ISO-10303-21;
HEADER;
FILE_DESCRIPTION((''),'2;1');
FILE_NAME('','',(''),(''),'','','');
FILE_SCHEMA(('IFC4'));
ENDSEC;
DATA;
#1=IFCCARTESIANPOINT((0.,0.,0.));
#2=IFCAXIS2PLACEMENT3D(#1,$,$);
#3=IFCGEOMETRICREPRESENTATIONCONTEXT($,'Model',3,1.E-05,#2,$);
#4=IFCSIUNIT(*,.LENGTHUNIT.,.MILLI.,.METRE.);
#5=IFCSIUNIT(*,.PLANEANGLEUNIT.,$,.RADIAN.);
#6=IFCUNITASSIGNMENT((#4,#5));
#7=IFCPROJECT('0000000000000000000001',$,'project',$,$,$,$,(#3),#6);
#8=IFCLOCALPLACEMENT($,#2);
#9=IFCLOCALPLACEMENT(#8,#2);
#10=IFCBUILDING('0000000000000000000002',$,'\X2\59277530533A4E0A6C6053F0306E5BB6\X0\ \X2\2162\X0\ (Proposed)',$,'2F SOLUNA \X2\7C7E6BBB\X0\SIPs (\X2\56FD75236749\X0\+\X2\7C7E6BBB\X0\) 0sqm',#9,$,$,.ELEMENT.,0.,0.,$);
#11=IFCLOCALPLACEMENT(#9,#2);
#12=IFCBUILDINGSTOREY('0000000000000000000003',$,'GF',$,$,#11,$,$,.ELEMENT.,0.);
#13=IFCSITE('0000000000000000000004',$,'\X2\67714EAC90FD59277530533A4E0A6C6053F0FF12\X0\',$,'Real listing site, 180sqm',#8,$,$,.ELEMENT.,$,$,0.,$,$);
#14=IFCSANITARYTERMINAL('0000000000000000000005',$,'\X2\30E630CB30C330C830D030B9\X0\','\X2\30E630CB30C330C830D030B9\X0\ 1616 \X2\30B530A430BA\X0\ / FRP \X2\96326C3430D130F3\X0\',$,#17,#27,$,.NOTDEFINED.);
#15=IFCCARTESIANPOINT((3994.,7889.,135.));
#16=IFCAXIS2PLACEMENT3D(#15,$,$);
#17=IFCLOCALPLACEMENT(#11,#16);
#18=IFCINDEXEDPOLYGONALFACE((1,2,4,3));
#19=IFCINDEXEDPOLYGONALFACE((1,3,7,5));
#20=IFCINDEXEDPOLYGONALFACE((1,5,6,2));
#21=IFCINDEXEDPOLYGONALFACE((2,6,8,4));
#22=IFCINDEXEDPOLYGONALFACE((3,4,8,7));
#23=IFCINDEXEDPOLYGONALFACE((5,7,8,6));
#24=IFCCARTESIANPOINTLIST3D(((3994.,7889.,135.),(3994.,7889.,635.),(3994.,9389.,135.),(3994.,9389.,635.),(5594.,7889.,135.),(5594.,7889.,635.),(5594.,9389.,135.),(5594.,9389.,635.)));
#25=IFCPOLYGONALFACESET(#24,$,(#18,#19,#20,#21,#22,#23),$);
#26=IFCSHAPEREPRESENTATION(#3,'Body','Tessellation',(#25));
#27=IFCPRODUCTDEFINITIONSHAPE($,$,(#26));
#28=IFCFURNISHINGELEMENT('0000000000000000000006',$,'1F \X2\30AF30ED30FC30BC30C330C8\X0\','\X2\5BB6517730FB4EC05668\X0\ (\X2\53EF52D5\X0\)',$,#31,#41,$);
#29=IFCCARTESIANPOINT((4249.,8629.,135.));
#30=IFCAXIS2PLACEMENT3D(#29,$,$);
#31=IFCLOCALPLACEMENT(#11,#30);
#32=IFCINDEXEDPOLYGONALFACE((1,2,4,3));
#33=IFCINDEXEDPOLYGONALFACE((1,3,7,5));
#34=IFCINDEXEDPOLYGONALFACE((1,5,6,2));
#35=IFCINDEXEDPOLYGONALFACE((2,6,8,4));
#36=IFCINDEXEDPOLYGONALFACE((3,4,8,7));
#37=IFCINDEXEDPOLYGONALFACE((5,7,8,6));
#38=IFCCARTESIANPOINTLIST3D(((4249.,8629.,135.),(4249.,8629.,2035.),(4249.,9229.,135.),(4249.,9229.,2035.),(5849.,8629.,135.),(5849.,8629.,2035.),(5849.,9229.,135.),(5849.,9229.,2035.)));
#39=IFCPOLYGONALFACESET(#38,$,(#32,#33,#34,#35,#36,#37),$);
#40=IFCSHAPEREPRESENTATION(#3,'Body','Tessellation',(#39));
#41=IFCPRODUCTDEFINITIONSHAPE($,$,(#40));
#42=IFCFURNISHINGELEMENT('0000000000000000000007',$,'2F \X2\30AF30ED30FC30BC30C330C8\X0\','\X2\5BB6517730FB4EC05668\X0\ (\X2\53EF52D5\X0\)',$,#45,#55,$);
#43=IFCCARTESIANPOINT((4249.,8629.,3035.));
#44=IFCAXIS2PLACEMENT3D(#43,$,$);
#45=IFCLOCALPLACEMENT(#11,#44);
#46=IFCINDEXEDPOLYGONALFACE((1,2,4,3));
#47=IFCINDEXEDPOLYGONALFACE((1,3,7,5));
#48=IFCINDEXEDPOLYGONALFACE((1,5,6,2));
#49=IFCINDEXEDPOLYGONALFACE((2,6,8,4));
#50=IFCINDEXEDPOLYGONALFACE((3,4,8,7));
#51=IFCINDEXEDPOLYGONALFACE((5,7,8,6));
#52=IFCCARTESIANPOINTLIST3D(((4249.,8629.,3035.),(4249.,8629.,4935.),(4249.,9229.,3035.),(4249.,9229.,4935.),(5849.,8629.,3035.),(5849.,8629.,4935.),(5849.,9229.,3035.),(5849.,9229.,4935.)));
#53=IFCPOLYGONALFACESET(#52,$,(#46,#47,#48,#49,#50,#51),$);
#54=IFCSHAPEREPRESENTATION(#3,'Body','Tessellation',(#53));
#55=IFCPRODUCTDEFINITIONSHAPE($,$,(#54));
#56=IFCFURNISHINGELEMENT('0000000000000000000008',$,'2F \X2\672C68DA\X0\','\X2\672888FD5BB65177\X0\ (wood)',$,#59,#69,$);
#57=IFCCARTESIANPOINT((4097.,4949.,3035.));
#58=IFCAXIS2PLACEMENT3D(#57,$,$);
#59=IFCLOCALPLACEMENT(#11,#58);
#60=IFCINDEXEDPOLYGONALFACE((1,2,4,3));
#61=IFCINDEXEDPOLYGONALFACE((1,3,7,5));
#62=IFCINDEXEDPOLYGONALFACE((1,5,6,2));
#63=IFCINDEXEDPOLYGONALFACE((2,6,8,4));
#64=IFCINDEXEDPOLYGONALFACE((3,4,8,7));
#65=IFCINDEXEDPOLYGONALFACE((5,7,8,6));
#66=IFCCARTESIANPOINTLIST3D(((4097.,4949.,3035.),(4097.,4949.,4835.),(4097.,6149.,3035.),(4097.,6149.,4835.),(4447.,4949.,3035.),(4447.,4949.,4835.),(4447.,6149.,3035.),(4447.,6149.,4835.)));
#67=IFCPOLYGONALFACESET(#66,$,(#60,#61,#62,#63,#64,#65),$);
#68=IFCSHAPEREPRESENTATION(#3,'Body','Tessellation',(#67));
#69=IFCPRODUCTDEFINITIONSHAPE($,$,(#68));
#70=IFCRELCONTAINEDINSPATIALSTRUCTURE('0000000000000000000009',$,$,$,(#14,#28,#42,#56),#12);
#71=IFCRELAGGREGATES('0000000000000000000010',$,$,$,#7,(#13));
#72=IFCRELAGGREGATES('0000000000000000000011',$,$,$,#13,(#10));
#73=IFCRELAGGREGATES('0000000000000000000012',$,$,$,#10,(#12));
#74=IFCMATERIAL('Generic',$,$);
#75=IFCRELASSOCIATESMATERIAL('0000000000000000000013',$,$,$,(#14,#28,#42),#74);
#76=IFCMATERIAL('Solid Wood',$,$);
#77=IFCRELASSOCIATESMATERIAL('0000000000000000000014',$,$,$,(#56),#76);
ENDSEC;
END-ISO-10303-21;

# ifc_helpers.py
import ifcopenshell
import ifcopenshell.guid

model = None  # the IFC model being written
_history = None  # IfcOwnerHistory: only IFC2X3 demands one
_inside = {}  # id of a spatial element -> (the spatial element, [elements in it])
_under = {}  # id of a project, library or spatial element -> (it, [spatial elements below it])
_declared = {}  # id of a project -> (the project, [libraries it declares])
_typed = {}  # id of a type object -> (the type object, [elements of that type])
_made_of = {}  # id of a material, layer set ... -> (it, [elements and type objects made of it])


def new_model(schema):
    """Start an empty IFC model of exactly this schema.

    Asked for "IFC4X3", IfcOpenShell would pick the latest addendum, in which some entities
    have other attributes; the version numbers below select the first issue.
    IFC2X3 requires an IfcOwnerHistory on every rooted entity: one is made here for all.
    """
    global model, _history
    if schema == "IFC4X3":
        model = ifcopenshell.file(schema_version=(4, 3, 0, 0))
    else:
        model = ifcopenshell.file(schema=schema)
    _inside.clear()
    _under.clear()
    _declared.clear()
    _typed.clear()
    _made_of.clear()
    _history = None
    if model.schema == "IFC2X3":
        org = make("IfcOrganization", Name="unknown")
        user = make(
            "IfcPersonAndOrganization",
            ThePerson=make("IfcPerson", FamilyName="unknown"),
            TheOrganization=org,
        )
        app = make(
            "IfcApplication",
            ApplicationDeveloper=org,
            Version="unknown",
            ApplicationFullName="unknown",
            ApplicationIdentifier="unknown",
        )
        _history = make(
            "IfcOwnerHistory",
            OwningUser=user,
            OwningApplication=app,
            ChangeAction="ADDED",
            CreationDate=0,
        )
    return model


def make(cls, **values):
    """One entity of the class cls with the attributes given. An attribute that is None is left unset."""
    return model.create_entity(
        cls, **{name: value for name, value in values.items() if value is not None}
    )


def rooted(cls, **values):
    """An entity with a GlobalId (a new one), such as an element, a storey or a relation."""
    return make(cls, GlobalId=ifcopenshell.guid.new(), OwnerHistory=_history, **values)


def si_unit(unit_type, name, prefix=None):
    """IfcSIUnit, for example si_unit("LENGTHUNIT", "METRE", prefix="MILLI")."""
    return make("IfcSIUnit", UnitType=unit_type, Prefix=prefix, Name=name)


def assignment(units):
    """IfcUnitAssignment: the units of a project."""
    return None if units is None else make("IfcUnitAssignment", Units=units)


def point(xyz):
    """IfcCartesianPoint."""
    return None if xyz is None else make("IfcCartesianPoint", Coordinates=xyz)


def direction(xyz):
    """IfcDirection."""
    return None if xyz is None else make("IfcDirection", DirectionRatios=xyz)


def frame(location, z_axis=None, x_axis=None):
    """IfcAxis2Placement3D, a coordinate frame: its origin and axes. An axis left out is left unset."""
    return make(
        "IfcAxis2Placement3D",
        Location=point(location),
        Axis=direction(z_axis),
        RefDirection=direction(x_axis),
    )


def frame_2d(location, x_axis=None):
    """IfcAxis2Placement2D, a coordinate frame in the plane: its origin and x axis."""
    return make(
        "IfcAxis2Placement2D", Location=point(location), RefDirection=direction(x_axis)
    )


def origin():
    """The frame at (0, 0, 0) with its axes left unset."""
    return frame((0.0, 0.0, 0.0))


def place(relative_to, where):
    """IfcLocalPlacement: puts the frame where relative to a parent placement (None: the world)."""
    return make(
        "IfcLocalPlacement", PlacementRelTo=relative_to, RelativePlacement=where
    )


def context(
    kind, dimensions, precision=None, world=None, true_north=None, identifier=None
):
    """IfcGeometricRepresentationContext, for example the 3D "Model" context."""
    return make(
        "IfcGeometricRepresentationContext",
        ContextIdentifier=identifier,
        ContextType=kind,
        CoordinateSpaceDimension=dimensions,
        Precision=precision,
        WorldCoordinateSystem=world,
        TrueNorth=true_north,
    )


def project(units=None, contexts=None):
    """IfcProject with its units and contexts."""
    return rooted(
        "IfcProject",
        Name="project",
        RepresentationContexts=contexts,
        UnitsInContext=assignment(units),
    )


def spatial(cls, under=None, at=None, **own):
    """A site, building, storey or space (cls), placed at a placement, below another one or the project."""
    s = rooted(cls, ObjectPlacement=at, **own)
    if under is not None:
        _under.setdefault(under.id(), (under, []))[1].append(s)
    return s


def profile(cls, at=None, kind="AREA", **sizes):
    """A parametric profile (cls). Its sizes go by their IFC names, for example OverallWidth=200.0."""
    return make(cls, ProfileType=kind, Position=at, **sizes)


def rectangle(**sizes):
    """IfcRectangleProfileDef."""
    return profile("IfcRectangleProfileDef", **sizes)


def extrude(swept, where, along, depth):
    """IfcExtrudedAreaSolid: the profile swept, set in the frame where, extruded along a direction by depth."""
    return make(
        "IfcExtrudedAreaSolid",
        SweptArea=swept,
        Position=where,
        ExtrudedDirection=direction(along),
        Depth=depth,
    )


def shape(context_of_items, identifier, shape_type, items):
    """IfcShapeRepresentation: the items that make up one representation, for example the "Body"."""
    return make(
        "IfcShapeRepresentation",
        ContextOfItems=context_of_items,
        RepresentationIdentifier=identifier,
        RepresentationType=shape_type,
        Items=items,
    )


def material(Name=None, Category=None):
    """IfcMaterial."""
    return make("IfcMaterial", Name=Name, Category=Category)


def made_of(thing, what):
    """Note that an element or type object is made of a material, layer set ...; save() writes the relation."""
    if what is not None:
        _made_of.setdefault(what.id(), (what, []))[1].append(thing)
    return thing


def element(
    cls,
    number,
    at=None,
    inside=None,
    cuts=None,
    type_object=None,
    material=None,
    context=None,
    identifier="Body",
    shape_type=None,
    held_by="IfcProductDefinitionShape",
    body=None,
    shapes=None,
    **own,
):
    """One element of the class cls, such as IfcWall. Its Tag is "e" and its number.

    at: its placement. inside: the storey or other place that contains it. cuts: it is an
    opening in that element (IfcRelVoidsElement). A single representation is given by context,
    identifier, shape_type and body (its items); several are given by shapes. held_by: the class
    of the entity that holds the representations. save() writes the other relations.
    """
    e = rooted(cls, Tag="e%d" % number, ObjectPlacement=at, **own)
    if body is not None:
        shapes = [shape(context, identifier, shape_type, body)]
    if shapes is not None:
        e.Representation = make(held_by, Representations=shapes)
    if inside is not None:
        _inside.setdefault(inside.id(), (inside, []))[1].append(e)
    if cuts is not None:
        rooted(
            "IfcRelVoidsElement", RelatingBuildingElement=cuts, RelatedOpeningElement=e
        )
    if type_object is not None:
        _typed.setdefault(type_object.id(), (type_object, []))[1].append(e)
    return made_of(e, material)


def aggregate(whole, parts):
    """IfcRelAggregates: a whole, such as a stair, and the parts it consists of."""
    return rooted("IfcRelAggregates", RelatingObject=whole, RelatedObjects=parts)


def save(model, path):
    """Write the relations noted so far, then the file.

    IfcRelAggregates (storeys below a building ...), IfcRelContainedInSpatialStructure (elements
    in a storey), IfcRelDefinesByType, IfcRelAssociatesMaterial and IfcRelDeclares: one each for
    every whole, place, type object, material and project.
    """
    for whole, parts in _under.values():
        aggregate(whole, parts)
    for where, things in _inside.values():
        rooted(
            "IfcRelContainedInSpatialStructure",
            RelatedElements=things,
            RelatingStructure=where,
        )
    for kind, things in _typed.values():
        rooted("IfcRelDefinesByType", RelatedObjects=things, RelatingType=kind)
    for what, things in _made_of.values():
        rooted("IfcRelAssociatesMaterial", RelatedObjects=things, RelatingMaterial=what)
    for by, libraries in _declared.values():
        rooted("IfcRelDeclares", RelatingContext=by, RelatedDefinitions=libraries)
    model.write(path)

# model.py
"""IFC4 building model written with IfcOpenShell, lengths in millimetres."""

from ifc_helpers import new_model, si_unit, frame, frame_2d, origin, place, context, project, spatial, rectangle, extrude, material, element, save


model = new_model("IFC4")

# Units and contexts
model_context = context("Model", 3, precision=1e-05, world=origin())
ifc_project = project(units=[si_unit("LENGTHUNIT", "METRE", prefix="MILLI"), si_unit("PLANEANGLEUNIT", "RADIAN")], contexts=[model_context])

# Site, building, storey
site_placement = place(None, origin())
site = spatial("IfcSite", under=ifc_project, at=site_placement, Name="東京都大田区上池台２", ObjectType="Real listing site, 180sqm", CompositionType="ELEMENT", RefElevation=0.0)
building_placement = place(site_placement, origin())
building = spatial("IfcBuilding", under=site, at=building_placement, Name="大田区上池台の家 Ⅲ (Proposed)", ObjectType="2F SOLUNA 籾殻SIPs (国産杉+籾殻) 0sqm", CompositionType="ELEMENT", ElevationOfRefHeight=0.0, ElevationOfTerrain=0.0)
storey_placement = place(building_placement, origin())
storey = spatial("IfcBuildingStorey", under=building, at=storey_placement, Name="GF", CompositionType="ELEMENT", Elevation=0.0)

# Shared definitions
ifc_material_1 = material(Name="Solid Wood")

# Shared definitions
ifc_material_2 = material(Name="Generic")

# Sanitary terminal
sanitary_terminal_placement = place(storey_placement, frame((3994.0, 7889.0, 135.0)))
element("IfcSanitaryTerminal", 1, at=sanitary_terminal_placement, inside=storey, material=ifc_material_2, Name="ユニットバス", Description="ユニットバス 1616 サイズ / FRP 防水パン", PredefinedType="NOTDEFINED", context=model_context, shape_type="SweptSolid", body=[
    extrude(rectangle(XDim=1600.0, YDim=1500.0, at=frame_2d((800.0, 750.0))), frame((3994.0, 7889.0, 135.0)), (0.0, 0.0, 1.0), 500.0),
])

# Furnishing elements
furnishing_1_placement = place(storey_placement, frame((4249.0, 8629.0, 135.0)))
element("IfcFurnishingElement", 2, at=furnishing_1_placement, inside=storey, material=ifc_material_2, Name="1F クローゼット", Description="家具・什器 (可動)", context=model_context, shape_type="SweptSolid", body=[
    extrude(rectangle(XDim=1600.0, YDim=600.0, at=frame_2d((800.0, 300.0))), frame((4249.0, 8629.0, 135.0)), (0.0, 0.0, 1.0), 1900.0),
])
furnishing_2_placement = place(storey_placement, frame((4249.0, 8629.0, 3035.0)))
element("IfcFurnishingElement", 3, at=furnishing_2_placement, inside=storey, material=ifc_material_2, Name="2F クローゼット", Description="家具・什器 (可動)", context=model_context, shape_type="SweptSolid", body=[
    extrude(rectangle(XDim=1600.0, YDim=600.0, at=frame_2d((800.0, 300.0))), frame((4249.0, 8629.0, 3035.0)), (0.0, 0.0, 1.0), 1900.0),
])
furnishing_3_placement = place(storey_placement, frame((4097.0, 4949.0, 3035.0)))
element("IfcFurnishingElement", 4, at=furnishing_3_placement, inside=storey, material=ifc_material_1, Name="2F 本棚", Description="木製家具 (wood)", context=model_context, shape_type="SweptSolid", body=[
    extrude(rectangle(XDim=350.0, YDim=1200.0, at=frame_2d((175.0, 600.0))), frame((4097.0, 4949.0, 3035.0)), (0.0, 0.0, 1.0), 1800.0),
])

save(model, "model.ifc")
